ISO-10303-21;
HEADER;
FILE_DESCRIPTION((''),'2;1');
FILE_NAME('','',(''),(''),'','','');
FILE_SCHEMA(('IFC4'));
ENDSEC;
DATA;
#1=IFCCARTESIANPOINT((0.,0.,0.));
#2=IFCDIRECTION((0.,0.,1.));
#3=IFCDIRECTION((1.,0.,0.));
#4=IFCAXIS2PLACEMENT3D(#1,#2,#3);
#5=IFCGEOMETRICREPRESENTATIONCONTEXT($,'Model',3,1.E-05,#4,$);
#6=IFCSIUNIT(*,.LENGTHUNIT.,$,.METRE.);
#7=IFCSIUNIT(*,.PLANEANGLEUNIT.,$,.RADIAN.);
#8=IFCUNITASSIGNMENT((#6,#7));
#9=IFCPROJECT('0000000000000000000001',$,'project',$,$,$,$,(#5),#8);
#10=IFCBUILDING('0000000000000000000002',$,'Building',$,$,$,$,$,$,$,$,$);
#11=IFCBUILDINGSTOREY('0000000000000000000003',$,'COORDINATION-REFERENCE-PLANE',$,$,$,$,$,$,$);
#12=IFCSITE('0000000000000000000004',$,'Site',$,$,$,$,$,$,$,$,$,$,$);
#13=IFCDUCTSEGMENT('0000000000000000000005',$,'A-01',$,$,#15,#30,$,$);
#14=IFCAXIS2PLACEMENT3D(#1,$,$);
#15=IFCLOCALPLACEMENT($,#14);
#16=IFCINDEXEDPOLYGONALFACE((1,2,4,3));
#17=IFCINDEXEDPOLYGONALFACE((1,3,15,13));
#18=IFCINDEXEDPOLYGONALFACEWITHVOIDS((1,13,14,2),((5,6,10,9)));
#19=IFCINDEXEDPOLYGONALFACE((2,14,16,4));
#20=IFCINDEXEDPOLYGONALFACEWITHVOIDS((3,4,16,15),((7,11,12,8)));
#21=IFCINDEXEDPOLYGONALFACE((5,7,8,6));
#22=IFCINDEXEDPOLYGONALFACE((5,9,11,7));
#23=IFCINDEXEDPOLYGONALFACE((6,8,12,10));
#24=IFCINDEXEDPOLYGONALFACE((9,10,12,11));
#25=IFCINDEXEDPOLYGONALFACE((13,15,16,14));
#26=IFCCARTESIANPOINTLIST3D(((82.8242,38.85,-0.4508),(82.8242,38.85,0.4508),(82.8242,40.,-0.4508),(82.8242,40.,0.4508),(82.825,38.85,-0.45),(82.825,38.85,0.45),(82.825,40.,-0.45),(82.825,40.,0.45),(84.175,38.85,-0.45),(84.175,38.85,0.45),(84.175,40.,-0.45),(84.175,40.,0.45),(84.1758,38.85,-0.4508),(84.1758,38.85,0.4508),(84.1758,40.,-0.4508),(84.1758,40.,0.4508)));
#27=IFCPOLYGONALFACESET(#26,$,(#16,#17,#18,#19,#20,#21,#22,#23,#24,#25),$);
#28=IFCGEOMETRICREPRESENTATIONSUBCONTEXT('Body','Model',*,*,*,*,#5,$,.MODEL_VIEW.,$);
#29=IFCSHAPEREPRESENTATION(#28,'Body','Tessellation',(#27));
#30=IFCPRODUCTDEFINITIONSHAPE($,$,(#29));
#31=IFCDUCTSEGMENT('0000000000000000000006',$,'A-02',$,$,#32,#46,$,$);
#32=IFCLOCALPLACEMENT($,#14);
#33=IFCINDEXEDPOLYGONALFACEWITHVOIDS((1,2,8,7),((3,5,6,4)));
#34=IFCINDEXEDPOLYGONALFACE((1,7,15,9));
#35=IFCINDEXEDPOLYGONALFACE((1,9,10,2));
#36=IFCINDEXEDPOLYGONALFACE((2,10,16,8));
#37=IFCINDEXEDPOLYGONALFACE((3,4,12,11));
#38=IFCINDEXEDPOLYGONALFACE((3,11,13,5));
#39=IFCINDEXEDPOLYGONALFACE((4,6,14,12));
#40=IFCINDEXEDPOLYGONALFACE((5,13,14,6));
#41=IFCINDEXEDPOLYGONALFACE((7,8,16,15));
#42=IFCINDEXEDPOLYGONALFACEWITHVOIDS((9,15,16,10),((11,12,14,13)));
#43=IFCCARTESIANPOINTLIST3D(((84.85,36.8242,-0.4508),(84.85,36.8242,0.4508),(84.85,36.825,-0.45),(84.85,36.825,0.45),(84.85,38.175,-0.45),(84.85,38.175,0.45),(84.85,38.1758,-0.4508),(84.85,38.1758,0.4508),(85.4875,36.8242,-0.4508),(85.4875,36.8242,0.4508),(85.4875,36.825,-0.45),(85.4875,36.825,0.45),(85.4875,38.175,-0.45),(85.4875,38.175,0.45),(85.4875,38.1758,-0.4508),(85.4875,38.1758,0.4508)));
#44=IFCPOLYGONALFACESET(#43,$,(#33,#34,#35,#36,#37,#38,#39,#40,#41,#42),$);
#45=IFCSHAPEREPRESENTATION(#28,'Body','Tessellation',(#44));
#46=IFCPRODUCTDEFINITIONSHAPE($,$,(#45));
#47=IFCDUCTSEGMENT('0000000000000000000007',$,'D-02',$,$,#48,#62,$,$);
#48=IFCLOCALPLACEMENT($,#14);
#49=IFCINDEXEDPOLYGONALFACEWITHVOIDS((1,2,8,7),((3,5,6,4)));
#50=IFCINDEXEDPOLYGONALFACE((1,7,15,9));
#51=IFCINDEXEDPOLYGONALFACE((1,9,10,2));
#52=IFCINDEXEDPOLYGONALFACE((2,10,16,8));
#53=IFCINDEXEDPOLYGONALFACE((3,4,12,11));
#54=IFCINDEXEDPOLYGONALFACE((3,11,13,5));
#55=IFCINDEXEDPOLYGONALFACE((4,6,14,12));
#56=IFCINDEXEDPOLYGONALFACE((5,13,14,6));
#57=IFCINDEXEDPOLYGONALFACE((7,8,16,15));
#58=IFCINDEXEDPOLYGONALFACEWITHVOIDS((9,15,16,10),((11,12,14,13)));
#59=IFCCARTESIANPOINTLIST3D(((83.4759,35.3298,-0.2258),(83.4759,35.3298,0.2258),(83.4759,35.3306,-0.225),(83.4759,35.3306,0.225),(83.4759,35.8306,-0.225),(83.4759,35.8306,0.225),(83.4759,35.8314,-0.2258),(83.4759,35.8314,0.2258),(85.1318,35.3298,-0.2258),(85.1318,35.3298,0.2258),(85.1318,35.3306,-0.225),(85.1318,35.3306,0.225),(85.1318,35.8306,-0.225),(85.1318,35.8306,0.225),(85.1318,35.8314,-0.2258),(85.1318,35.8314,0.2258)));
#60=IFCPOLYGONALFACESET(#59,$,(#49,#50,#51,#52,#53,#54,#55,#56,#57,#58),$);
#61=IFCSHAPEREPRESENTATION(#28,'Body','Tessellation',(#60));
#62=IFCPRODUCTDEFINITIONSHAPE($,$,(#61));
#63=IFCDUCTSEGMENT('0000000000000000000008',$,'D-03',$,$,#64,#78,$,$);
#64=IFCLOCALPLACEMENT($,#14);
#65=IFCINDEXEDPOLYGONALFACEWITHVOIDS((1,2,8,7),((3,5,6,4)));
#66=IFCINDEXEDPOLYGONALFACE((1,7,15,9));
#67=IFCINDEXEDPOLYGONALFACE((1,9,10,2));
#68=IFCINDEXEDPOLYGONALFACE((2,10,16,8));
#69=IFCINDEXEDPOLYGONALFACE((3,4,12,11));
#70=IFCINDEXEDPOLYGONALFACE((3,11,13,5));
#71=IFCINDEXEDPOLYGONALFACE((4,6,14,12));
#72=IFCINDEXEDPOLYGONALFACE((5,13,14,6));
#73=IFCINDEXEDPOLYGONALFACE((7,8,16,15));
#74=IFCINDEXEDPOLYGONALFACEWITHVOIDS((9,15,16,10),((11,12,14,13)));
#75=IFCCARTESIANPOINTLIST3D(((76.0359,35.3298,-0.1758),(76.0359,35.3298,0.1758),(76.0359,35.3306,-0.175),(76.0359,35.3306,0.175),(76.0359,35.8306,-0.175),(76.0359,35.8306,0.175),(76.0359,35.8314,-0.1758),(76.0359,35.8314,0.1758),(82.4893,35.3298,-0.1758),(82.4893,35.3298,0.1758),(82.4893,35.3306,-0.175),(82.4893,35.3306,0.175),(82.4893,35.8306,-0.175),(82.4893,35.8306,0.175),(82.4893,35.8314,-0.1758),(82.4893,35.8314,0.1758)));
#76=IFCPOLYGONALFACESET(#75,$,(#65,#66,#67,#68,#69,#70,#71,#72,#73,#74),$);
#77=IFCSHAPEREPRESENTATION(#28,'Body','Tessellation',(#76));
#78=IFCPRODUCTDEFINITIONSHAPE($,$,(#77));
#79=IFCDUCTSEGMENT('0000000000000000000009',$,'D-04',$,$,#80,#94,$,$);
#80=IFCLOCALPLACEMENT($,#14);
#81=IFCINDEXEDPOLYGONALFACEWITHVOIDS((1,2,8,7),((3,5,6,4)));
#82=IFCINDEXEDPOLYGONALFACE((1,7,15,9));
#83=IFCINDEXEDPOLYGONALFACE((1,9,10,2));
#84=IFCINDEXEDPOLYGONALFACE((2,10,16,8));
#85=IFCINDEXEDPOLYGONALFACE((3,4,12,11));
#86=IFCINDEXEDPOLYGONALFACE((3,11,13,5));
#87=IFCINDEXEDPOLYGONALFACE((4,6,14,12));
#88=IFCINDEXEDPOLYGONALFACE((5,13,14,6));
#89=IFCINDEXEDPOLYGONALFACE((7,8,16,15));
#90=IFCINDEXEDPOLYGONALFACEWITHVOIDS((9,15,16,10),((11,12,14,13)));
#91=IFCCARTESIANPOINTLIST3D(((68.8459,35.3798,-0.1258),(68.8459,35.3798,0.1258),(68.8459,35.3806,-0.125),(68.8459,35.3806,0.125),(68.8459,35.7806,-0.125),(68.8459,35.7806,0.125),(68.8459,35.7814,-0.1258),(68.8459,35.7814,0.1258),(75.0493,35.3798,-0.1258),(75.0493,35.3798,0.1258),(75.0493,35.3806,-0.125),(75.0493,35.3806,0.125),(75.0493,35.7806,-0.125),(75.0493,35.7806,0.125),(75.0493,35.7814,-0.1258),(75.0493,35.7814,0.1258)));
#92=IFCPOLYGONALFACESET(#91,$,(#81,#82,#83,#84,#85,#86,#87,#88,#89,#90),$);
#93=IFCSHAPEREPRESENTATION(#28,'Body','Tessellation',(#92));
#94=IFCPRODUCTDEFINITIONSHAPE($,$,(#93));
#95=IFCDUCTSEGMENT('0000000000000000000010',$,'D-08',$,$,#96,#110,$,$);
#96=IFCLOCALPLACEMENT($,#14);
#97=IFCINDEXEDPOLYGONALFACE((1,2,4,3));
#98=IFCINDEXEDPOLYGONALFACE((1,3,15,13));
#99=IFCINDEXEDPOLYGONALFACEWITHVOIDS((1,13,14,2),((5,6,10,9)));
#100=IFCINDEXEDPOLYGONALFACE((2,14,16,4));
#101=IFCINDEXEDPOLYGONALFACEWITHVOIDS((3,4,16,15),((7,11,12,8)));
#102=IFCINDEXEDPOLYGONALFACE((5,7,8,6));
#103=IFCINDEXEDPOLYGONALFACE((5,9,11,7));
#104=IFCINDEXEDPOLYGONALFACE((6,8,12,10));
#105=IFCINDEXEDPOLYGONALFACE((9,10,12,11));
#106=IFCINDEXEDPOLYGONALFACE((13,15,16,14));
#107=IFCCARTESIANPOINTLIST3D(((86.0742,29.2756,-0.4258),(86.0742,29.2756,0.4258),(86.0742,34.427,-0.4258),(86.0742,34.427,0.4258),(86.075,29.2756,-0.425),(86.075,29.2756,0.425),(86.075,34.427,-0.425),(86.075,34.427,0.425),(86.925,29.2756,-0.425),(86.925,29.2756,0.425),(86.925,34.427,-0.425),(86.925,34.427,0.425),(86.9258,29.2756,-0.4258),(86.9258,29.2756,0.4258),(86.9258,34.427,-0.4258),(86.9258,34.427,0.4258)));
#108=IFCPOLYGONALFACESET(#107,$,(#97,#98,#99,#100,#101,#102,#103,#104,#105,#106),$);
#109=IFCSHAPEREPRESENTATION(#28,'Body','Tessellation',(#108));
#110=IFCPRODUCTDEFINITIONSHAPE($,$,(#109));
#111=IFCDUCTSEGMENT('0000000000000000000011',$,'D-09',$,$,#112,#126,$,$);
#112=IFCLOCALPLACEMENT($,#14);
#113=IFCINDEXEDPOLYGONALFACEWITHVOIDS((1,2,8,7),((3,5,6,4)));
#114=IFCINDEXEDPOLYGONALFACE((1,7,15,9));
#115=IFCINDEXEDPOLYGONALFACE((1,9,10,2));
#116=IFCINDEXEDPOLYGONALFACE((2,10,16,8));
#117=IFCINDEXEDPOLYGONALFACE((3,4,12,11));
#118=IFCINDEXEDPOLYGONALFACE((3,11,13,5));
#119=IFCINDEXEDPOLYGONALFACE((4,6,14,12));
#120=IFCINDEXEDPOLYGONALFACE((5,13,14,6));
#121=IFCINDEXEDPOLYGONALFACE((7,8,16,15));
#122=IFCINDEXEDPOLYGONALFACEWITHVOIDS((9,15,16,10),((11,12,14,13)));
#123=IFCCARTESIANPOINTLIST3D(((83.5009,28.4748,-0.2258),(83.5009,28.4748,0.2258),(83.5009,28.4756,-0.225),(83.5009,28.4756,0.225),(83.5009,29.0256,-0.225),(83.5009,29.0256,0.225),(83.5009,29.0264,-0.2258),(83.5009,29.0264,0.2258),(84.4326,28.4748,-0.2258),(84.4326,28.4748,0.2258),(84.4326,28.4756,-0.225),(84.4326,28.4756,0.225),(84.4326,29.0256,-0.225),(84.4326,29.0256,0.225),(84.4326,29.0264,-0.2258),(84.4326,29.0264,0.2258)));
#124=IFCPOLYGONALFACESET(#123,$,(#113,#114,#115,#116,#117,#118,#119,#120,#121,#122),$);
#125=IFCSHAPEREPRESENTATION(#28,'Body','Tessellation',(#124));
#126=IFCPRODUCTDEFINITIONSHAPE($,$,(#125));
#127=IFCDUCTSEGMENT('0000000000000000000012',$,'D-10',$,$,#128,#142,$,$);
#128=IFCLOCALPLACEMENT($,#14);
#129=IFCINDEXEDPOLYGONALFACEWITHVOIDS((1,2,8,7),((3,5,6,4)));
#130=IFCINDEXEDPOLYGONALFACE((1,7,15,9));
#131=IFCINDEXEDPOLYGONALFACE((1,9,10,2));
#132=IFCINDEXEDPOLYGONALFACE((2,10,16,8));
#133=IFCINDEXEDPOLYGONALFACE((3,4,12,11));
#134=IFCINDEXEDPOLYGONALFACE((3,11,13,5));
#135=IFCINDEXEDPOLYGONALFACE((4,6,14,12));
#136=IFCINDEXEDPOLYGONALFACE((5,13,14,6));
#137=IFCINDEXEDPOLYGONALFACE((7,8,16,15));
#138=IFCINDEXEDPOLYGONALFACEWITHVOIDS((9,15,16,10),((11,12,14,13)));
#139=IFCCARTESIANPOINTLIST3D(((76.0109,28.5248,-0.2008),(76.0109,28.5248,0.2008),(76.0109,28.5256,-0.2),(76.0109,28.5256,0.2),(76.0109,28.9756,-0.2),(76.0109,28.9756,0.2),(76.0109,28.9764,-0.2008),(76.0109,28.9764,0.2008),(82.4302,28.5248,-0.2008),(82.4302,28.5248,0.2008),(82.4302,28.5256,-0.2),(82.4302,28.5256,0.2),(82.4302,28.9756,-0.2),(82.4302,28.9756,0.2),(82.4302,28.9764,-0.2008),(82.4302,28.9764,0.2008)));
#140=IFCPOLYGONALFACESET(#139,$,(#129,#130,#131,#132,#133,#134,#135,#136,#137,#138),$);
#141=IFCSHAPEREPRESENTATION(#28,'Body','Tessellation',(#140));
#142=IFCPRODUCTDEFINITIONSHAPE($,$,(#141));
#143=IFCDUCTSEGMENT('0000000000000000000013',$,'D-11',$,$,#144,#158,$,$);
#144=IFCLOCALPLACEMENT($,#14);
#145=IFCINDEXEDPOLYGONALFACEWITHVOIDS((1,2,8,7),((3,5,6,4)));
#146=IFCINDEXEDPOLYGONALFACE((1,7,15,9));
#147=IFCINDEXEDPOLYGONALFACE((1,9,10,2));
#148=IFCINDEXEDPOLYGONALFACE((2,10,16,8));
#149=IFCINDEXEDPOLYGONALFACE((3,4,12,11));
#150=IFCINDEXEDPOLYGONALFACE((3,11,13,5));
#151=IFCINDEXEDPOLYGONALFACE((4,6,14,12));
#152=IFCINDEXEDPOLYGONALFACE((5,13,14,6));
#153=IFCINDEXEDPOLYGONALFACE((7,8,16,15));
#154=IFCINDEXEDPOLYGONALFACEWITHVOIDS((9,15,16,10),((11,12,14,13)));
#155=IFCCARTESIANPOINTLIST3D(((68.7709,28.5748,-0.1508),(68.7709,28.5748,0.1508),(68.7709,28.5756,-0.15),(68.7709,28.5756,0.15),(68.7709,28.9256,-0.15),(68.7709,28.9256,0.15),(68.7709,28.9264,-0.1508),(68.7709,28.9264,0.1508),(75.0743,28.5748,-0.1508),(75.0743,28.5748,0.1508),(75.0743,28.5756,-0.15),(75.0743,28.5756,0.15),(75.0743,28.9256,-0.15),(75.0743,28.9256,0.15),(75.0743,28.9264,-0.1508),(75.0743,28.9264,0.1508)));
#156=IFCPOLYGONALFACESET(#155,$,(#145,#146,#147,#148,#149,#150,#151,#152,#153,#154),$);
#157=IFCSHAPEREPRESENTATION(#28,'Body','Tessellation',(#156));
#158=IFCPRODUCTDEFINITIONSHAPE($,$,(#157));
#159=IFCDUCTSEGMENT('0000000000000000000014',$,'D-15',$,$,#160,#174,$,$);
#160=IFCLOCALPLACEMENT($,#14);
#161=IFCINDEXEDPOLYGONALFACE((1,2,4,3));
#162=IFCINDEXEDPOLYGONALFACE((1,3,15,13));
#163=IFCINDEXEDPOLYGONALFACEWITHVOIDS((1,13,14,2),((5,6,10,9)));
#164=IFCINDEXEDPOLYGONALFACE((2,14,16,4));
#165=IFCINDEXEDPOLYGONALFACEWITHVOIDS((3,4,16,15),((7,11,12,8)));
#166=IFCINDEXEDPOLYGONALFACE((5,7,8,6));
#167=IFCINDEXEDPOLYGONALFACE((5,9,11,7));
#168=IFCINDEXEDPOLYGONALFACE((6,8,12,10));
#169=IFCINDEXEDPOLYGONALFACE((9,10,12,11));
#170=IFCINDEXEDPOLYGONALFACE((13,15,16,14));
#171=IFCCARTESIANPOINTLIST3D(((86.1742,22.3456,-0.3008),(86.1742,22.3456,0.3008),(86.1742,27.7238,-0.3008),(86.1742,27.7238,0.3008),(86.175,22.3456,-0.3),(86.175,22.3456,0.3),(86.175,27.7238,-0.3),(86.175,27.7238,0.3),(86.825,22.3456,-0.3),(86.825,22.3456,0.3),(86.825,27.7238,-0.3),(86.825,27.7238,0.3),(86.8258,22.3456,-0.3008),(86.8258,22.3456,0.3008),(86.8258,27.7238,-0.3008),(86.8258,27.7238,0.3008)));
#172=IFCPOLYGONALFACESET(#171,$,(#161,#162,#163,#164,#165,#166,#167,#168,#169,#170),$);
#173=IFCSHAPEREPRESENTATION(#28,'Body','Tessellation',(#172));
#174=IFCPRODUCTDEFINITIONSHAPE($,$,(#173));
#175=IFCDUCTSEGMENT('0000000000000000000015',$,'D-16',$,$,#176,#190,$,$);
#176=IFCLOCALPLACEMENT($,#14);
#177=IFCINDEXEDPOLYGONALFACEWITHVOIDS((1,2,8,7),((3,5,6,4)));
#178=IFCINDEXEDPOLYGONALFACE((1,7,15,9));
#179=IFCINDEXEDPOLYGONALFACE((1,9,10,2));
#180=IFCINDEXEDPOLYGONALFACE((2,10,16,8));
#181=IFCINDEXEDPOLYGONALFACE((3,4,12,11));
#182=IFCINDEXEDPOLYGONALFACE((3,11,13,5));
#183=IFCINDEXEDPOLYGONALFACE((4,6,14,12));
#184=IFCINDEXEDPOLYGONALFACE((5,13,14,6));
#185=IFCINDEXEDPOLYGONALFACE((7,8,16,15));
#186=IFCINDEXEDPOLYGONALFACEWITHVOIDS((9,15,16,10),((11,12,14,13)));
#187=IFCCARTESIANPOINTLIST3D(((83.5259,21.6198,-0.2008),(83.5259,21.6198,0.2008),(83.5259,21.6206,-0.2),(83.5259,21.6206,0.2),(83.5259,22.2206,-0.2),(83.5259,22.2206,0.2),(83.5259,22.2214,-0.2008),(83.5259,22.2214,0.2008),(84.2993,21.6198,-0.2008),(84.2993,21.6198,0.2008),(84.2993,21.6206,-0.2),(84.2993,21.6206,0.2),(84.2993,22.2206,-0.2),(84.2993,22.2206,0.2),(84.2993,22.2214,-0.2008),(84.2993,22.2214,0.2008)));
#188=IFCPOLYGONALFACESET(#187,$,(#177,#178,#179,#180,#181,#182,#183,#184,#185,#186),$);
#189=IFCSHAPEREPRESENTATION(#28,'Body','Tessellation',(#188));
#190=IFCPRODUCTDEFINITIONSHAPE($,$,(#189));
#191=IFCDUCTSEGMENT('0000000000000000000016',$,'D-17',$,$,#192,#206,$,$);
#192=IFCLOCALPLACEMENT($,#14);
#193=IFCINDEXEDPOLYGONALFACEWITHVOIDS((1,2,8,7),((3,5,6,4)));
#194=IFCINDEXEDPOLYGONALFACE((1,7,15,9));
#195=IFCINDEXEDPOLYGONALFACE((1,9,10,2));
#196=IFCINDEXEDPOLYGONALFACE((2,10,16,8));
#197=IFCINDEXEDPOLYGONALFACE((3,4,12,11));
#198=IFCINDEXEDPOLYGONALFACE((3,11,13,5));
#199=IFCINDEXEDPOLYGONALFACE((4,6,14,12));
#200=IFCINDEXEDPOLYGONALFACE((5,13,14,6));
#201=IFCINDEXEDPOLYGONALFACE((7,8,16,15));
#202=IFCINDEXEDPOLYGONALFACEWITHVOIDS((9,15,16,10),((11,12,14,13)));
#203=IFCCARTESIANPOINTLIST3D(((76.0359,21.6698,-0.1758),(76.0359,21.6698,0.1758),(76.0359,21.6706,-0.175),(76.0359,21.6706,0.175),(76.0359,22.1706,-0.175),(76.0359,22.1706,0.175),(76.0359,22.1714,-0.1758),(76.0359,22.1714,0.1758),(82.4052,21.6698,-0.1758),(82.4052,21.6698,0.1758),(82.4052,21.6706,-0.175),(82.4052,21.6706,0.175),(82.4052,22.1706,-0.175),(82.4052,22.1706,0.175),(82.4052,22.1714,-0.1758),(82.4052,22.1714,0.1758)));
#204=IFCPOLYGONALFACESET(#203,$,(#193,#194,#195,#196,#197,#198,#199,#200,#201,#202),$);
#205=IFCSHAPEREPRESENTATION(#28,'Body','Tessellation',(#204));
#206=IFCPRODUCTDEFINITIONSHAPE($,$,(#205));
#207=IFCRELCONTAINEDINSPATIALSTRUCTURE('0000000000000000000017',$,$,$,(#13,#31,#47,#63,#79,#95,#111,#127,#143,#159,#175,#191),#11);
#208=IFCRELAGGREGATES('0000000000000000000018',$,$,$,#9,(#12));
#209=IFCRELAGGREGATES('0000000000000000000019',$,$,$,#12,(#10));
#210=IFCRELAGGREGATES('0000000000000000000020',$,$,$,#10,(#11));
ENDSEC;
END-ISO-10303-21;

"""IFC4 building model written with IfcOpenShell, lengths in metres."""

from ifc_helpers import new_model, si_unit, frame, origin, origin_with_axes, place, context, subcontext, project, spatial, hollow_rectangle, extrude, element, save


model = new_model("IFC4")

# Units and contexts
model_context = context("Model", 3, precision=1e-05, world=origin_with_axes())
body_context = subcontext(model_context, "Body", "Model", "MODEL_VIEW")
ifc_project = project(units=[si_unit("LENGTHUNIT", "METRE"), si_unit("PLANEANGLEUNIT", "RADIAN")], contexts=[model_context])

# Site, building, storey
site = spatial("IfcSite", under=ifc_project, Name="Site")
building = spatial("IfcBuilding", under=site, Name="Building")
storey = spatial("IfcBuildingStorey", under=building, Name="COORDINATION-REFERENCE-PLANE")

# Duct segments
duct_segment_1_placement = place(None, frame((83.5, 38.85, 0.0), z_axis=(0.0, 1.0, 0.0), x_axis=(1.0, 0.0, 0.0)))
element("IfcDuctSegment", 1, at=duct_segment_1_placement, inside=storey, Name="A-01", context=body_context, shape_type="SweptSolid", body=[
    extrude(hollow_rectangle(XDim=1.3516, YDim=0.9016, WallThickness=0.0008), origin(), (0.0, 0.0, 1.0), 1.15),
])
duct_segment_2_placement = place(None, frame((84.85, 37.5, 0.0), z_axis=(1.0, 0.0, 0.0), x_axis=(0.0, 1.0, 0.0)))
element("IfcDuctSegment", 2, at=duct_segment_2_placement, inside=storey, Name="A-02", context=body_context, shape_type="SweptSolid", body=[
    extrude(hollow_rectangle(XDim=1.3516, YDim=0.9016, WallThickness=0.0008), origin(), (0.0, 0.0, 1.0), 0.6375),
])
duct_segment_3_placement = place(None, frame((83.4759, 35.5806, 0.0), z_axis=(1.0, 0.0, 0.0), x_axis=(0.0, 1.0, 0.0)))
element("IfcDuctSegment", 3, at=duct_segment_3_placement, inside=storey, Name="D-02", context=body_context, shape_type="SweptSolid", body=[
    extrude(hollow_rectangle(XDim=0.5016, YDim=0.4516, WallThickness=0.0008), origin(), (0.0, 0.0, 1.0), 1.6559),
])
duct_segment_4_placement = place(None, frame((76.0359, 35.5806, 0.0), z_axis=(1.0, 0.0, 0.0), x_axis=(0.0, 1.0, 0.0)))
element("IfcDuctSegment", 4, at=duct_segment_4_placement, inside=storey, Name="D-03", context=body_context, shape_type="SweptSolid", body=[
    extrude(hollow_rectangle(XDim=0.5016, YDim=0.3516, WallThickness=0.0008), origin(), (0.0, 0.0, 1.0), 6.4534),
])
duct_segment_5_placement = place(None, frame((68.8459, 35.5806, 0.0), z_axis=(1.0, 0.0, 0.0), x_axis=(0.0, 1.0, 0.0)))
element("IfcDuctSegment", 5, at=duct_segment_5_placement, inside=storey, Name="D-04", context=body_context, shape_type="SweptSolid", body=[
    extrude(hollow_rectangle(XDim=0.4016, YDim=0.2516, WallThickness=0.0008), origin(), (0.0, 0.0, 1.0), 6.2034),
])
duct_segment_6_placement = place(None, frame((86.5, 29.2756, 0.0), z_axis=(0.0, 1.0, 0.0), x_axis=(1.0, 0.0, 0.0)))
element("IfcDuctSegment", 6, at=duct_segment_6_placement, inside=storey, Name="D-08", context=body_context, shape_type="SweptSolid", body=[
    extrude(hollow_rectangle(XDim=0.8516, YDim=0.8516, WallThickness=0.0008), origin(), (0.0, 0.0, 1.0), 5.1514),
])
duct_segment_7_placement = place(None, frame((83.5009, 28.7506, 0.0), z_axis=(1.0, 0.0, 0.0), x_axis=(0.0, 1.0, 0.0)))
element("IfcDuctSegment", 7, at=duct_segment_7_placement, inside=storey, Name="D-09", context=body_context, shape_type="SweptSolid", body=[
    extrude(hollow_rectangle(XDim=0.5516, YDim=0.4516, WallThickness=0.0008), origin(), (0.0, 0.0, 1.0), 0.9316),
])
duct_segment_8_placement = place(None, frame((76.0109, 28.7506, 0.0), z_axis=(1.0, 0.0, 0.0), x_axis=(0.0, 1.0, 0.0)))
element("IfcDuctSegment", 8, at=duct_segment_8_placement, inside=storey, Name="D-10", context=body_context, shape_type="SweptSolid", body=[
    extrude(hollow_rectangle(XDim=0.4516, YDim=0.4016, WallThickness=0.0008), origin(), (0.0, 0.0, 1.0), 6.4193),
])
duct_segment_9_placement = place(None, frame((68.7709, 28.7506, 0.0), z_axis=(1.0, 0.0, 0.0), x_axis=(0.0, 1.0, 0.0)))
element("IfcDuctSegment", 9, at=duct_segment_9_placement, inside=storey, Name="D-11", context=body_context, shape_type="SweptSolid", body=[
    extrude(hollow_rectangle(XDim=0.3516, YDim=0.3016, WallThickness=0.0008), origin(), (0.0, 0.0, 1.0), 6.3034),
])
duct_segment_10_placement = place(None, frame((86.5, 22.3456, 0.0), z_axis=(0.0, 1.0, 0.0), x_axis=(1.0, 0.0, 0.0)))
element("IfcDuctSegment", 10, at=duct_segment_10_placement, inside=storey, Name="D-15", context=body_context, shape_type="SweptSolid", body=[
    extrude(hollow_rectangle(XDim=0.6516, YDim=0.6016, WallThickness=0.0008), origin(), (0.0, 0.0, 1.0), 5.3782),
])
duct_segment_11_placement = place(None, frame((83.5259, 21.9206, 0.0), z_axis=(1.0, 0.0, 0.0), x_axis=(0.0, 1.0, 0.0)))
element("IfcDuctSegment", 11, at=duct_segment_11_placement, inside=storey, Name="D-16", context=body_context, shape_type="SweptSolid", body=[
    extrude(hollow_rectangle(XDim=0.6016, YDim=0.4016, WallThickness=0.0008), origin(), (0.0, 0.0, 1.0), 0.7733),
])
duct_segment_12_placement = place(None, frame((76.0359, 21.9206, 0.0), z_axis=(1.0, 0.0, 0.0), x_axis=(0.0, 1.0, 0.0)))
element("IfcDuctSegment", 12, at=duct_segment_12_placement, inside=storey, Name="D-17", context=body_context, shape_type="SweptSolid", body=[
    extrude(hollow_rectangle(XDim=0.5016, YDim=0.3516, WallThickness=0.0008), origin(), (0.0, 0.0, 1.0), 6.3693),
])

save(model, "model.ifc")
